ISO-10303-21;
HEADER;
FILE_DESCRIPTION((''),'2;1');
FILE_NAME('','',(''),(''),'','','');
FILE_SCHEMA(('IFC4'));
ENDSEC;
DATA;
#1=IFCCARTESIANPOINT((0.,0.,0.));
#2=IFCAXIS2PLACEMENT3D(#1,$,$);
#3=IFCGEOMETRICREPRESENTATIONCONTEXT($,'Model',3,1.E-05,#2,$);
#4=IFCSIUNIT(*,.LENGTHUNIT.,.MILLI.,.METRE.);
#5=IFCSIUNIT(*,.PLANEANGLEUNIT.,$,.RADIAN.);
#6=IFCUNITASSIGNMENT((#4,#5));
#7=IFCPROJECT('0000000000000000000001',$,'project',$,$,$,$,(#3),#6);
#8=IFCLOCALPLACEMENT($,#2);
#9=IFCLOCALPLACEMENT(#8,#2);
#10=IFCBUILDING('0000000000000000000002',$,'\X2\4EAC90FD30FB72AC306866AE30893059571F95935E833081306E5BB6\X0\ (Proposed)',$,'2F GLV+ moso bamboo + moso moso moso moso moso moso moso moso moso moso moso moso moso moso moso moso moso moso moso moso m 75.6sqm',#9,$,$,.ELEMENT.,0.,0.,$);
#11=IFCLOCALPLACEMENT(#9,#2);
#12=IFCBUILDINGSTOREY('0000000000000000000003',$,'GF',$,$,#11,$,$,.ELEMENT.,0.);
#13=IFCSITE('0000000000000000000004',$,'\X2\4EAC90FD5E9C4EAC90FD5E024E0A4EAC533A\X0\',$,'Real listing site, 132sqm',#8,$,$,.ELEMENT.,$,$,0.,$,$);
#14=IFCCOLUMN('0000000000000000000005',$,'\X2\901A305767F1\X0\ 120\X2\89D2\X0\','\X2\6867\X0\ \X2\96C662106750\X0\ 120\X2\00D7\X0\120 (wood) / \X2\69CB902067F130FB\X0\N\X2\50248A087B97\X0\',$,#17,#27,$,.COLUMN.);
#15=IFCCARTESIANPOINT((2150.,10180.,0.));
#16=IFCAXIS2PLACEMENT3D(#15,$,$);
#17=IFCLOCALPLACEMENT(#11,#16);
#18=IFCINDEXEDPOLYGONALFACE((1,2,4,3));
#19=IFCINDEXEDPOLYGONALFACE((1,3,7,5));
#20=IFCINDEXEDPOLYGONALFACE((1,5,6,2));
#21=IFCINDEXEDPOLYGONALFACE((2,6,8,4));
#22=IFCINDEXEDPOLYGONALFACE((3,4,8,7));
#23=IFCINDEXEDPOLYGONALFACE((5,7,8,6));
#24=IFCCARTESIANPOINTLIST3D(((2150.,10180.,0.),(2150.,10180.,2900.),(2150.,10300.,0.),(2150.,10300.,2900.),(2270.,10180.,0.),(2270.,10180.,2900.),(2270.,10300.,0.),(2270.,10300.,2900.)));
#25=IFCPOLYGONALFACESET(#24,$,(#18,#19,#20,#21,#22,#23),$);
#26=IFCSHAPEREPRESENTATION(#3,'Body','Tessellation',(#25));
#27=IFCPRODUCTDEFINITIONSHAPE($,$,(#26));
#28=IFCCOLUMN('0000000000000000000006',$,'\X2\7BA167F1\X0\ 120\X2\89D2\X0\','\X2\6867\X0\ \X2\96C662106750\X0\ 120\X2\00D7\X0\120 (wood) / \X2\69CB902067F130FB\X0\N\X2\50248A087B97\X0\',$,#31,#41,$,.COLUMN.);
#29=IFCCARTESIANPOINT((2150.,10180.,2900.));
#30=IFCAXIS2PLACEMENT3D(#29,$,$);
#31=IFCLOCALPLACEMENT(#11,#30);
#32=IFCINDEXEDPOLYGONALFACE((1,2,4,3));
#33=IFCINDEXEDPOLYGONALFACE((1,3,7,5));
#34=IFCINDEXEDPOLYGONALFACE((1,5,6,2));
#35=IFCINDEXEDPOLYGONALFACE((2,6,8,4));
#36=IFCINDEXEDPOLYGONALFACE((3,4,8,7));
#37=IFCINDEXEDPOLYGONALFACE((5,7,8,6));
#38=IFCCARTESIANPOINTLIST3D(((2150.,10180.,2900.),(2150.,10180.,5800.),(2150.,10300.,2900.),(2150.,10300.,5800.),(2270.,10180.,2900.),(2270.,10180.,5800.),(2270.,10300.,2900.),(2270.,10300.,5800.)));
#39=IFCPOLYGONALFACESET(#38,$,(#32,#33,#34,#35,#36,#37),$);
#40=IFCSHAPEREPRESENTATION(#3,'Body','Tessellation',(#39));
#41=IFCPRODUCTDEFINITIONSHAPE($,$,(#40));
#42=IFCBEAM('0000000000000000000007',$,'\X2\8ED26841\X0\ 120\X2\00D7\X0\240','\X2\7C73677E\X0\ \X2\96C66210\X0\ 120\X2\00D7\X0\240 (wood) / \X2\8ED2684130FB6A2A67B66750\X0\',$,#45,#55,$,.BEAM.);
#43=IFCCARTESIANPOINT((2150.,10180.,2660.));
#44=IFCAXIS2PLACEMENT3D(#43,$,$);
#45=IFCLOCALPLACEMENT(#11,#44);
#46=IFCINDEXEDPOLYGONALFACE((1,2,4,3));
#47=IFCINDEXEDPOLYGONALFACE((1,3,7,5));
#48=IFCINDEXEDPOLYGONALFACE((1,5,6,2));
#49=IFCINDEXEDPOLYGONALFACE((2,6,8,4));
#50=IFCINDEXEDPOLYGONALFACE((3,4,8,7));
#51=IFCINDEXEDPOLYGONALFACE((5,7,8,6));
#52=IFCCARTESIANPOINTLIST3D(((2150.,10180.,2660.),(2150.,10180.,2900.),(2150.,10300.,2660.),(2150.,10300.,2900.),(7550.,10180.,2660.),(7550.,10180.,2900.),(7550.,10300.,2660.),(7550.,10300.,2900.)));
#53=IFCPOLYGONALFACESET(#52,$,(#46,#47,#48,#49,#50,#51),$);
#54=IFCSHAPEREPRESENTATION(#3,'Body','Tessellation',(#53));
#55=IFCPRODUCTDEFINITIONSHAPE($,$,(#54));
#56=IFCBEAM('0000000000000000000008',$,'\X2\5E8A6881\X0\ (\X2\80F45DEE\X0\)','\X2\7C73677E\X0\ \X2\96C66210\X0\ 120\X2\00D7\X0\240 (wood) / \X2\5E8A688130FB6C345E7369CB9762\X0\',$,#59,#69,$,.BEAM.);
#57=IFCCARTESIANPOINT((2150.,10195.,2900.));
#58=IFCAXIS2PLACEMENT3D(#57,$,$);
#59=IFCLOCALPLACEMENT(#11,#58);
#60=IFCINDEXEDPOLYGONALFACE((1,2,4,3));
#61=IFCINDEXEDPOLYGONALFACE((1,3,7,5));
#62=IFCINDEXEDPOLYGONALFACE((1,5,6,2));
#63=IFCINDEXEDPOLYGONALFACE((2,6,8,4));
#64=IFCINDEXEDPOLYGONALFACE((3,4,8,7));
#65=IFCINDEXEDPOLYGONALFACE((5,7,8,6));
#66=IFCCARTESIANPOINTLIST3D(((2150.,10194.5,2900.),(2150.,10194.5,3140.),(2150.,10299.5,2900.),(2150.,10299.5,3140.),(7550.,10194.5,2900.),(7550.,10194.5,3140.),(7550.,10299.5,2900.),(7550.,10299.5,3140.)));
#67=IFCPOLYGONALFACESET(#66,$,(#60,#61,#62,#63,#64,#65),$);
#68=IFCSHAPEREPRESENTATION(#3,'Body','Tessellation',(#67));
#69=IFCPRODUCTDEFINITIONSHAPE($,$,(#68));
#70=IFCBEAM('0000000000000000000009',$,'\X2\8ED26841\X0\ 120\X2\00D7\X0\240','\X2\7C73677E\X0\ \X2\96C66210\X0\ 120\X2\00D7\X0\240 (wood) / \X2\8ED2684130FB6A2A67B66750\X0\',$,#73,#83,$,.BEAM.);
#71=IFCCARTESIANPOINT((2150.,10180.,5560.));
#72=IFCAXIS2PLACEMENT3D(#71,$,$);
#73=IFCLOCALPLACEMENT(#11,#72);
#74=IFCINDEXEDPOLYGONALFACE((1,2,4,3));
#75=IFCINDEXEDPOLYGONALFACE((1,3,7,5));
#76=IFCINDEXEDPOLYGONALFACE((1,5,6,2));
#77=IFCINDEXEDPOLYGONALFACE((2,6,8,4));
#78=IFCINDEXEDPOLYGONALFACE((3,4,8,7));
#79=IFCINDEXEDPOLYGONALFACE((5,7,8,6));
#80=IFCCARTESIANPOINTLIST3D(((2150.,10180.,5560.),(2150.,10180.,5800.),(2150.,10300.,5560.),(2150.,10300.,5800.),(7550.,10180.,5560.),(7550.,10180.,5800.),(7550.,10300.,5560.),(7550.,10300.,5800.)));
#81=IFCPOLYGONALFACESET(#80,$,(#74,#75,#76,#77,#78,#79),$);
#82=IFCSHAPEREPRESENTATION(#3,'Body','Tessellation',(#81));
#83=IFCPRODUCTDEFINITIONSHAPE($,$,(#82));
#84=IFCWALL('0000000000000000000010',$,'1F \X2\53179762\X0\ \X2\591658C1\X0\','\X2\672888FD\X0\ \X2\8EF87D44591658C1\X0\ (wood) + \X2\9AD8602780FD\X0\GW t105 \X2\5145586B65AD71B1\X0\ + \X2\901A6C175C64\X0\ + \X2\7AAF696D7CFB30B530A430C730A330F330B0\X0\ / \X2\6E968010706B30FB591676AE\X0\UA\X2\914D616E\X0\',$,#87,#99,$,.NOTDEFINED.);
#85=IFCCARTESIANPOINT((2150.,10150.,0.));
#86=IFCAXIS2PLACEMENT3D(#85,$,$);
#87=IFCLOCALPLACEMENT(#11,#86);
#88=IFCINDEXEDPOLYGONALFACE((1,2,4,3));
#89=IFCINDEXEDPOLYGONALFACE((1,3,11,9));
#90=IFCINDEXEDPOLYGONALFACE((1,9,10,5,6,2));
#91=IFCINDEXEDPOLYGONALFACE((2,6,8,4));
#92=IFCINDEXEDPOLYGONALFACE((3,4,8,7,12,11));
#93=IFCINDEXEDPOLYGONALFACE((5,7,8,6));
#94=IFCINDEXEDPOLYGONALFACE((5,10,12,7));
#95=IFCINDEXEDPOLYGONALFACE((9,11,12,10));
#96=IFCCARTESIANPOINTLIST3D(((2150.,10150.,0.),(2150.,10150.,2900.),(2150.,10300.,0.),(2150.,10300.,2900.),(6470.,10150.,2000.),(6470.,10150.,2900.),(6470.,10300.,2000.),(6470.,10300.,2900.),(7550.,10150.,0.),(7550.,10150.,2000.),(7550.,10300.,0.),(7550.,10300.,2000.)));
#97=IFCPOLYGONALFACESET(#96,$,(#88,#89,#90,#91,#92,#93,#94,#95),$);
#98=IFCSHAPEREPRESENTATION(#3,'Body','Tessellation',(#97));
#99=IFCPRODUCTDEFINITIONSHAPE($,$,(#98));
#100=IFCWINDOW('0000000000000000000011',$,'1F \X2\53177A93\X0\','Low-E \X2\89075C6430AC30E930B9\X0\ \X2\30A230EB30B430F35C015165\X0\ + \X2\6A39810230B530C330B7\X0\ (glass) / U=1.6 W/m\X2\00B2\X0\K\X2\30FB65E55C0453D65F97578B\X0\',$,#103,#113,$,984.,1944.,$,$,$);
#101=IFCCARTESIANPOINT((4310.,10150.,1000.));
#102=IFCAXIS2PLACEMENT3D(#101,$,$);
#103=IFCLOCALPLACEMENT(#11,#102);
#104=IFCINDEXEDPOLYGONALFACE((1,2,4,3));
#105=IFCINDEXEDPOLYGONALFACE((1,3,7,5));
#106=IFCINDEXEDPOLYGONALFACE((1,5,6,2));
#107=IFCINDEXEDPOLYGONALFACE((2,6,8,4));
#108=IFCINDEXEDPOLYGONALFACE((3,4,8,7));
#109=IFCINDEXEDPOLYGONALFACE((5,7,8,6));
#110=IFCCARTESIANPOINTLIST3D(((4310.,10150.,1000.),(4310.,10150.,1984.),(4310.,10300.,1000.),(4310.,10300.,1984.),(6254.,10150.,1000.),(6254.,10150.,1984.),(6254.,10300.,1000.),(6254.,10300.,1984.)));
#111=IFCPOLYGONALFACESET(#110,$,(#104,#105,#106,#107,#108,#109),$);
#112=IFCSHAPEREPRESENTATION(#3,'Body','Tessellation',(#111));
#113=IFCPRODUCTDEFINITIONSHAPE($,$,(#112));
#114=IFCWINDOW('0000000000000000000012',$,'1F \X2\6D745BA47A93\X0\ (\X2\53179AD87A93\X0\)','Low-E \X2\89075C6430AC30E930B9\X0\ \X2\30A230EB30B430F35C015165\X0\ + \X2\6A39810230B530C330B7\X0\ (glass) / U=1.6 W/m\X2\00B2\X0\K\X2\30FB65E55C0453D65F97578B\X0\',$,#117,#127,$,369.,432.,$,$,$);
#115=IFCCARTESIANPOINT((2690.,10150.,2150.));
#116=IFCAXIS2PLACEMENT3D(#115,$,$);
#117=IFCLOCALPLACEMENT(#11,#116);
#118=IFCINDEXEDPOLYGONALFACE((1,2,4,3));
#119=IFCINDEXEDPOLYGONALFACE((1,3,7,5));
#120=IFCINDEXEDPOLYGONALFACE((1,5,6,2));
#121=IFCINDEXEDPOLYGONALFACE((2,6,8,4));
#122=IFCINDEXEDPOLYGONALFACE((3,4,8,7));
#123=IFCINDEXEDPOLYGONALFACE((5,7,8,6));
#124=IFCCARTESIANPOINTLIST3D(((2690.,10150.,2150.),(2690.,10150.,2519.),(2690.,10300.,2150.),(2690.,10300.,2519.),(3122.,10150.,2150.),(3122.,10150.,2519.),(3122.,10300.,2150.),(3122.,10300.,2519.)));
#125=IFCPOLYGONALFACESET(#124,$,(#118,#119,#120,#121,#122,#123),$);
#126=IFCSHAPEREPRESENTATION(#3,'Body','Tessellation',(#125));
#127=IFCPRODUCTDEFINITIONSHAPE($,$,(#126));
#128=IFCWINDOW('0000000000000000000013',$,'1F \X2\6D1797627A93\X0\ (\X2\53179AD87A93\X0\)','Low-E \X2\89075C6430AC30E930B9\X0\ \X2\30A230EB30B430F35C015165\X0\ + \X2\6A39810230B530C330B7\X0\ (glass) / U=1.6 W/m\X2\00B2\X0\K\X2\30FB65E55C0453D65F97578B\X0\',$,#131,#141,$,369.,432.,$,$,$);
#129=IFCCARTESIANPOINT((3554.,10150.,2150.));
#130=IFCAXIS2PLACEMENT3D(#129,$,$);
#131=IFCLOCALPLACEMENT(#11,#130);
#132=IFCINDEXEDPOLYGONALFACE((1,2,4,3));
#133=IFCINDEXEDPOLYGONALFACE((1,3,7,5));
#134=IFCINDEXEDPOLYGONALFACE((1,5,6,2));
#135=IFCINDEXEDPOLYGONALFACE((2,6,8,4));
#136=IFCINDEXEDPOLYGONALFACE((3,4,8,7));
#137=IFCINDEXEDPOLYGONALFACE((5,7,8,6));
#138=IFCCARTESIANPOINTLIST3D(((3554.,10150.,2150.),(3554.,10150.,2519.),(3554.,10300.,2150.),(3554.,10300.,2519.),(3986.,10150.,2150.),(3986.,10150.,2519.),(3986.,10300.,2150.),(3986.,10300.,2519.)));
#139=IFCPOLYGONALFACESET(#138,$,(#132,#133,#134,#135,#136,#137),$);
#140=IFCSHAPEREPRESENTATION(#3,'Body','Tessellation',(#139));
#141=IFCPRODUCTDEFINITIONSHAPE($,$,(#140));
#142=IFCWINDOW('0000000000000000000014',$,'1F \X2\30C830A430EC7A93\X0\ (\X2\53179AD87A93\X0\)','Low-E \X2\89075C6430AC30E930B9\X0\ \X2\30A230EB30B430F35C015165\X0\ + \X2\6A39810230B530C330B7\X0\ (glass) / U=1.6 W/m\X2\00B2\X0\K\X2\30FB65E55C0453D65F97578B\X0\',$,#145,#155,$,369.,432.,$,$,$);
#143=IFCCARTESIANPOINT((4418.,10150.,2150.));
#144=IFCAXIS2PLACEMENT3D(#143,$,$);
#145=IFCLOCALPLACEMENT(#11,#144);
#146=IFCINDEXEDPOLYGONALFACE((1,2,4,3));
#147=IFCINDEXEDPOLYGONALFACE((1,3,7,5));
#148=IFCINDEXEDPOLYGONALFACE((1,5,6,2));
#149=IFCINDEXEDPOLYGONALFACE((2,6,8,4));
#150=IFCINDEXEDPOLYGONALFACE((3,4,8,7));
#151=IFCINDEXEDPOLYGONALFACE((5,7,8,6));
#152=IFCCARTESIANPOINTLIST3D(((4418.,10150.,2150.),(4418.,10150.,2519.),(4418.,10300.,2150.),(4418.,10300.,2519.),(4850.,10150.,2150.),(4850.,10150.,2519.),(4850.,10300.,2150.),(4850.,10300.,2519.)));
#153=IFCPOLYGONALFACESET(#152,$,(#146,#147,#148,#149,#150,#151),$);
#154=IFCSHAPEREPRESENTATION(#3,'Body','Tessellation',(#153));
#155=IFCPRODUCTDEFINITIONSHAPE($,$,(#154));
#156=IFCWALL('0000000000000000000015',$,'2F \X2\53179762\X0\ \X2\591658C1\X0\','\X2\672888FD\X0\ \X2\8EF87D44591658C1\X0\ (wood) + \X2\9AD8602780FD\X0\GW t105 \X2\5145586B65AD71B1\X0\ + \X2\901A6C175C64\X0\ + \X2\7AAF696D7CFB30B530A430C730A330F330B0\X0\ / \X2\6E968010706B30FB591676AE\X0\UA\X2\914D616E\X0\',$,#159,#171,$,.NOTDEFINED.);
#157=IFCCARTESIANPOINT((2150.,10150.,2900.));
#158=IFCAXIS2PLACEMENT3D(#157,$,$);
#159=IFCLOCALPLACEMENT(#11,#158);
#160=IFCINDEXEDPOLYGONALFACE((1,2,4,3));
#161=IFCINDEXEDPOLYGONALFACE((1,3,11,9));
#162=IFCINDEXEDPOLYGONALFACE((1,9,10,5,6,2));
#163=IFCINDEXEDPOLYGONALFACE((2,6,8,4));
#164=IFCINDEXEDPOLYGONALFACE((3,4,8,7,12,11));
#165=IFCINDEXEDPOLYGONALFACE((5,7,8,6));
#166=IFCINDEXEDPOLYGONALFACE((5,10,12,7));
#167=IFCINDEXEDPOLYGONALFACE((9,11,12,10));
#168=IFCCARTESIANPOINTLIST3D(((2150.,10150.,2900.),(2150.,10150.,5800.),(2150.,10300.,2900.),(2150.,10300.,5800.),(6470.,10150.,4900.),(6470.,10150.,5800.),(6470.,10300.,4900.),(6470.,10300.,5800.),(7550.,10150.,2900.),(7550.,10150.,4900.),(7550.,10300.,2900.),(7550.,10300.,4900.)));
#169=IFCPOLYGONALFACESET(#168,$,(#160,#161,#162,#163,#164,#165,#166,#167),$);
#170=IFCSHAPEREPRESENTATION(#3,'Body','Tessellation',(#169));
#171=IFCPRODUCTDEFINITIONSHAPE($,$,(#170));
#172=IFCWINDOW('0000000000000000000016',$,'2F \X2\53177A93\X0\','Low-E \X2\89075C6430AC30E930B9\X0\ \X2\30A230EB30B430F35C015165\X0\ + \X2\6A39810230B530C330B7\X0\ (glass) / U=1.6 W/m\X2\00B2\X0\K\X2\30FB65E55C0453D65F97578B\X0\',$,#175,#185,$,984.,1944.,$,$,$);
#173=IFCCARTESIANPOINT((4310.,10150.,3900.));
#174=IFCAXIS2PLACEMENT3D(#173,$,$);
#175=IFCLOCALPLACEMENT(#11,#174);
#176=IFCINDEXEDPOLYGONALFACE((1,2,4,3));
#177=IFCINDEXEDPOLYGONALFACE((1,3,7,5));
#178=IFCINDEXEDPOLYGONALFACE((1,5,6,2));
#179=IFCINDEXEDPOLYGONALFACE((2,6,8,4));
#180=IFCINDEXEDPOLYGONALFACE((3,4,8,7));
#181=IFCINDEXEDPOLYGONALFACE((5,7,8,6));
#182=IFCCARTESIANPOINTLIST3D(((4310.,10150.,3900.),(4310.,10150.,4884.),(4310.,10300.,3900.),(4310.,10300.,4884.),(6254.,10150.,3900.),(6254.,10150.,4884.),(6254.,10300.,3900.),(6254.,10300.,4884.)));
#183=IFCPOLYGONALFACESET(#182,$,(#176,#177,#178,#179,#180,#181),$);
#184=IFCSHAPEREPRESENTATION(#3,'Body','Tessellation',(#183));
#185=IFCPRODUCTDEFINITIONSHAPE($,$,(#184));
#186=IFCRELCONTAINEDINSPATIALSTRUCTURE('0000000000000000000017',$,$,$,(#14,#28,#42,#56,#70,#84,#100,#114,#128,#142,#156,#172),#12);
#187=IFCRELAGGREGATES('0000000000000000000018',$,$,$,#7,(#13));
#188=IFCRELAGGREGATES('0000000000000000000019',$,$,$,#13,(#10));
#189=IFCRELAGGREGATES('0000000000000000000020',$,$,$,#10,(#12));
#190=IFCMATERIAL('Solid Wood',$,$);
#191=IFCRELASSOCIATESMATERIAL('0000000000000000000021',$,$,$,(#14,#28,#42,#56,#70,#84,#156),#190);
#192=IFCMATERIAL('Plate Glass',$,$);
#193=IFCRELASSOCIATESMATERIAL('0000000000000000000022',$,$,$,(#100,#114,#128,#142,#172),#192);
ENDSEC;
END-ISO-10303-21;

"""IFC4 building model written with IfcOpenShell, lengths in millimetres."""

from ifc_helpers import new_model, si_unit, frame, frame_2d, origin, place, context, project, spatial, rectangle, extrude, material, element, fill, save


model = new_model("IFC4")

# Units and contexts
model_context = context("Model", 3, precision=1e-05, world=origin())
ifc_project = project(units=[si_unit("LENGTHUNIT", "METRE", prefix="MILLI"), si_unit("PLANEANGLEUNIT", "RADIAN")], contexts=[model_context])

# Site, building, storey
site_placement = place(None, origin())
site = spatial("IfcSite", under=ifc_project, at=site_placement, Name="京都府京都市上京区", ObjectType="Real listing site, 132sqm", CompositionType="ELEMENT", RefElevation=0.0)
building_placement = place(site_placement, origin())
building = spatial("IfcBuilding", under=site, at=building_placement, Name="京都・犬と暮らす土間広めの家 (Proposed)", ObjectType="2F GLV+ moso bamboo + moso moso moso moso moso moso moso moso moso moso moso moso moso moso moso moso moso moso moso moso m 75.6sqm", CompositionType="ELEMENT", ElevationOfRefHeight=0.0, ElevationOfTerrain=0.0)
storey_placement = place(building_placement, origin())
storey = spatial("IfcBuildingStorey", under=building, at=storey_placement, Name="GF", CompositionType="ELEMENT", Elevation=0.0)

# Columns
ifc_material_1 = material(Name="Solid Wood")
column_1_placement = place(storey_placement, frame((2150.0, 10180.0, 0.0)))
element("IfcColumn", 1, at=column_1_placement, inside=storey, material=ifc_material_1, Name="通し柱 120角", Description="桧 集成材 120×120 (wood) / 構造柱・N値計算", PredefinedType="COLUMN", context=model_context, shape_type="SweptSolid", body=[
    extrude(rectangle(XDim=120.0, YDim=120.0, at=frame_2d((60.0, 60.0))), frame((2150.0, 10180.0, 0.0)), (0.0, 0.0, 1.0), 2900.0),
])
column_2_placement = place(storey_placement, frame((2150.0, 10180.0, 2900.0)))
element("IfcColumn", 2, at=column_2_placement, inside=storey, material=ifc_material_1, Name="管柱 120角", Description="桧 集成材 120×120 (wood) / 構造柱・N値計算", PredefinedType="COLUMN", context=model_context, shape_type="SweptSolid", body=[
    extrude(rectangle(XDim=120.0, YDim=120.0, at=frame_2d((60.0, 60.0))), frame((2150.0, 10180.0, 2900.0)), (0.0, 0.0, 1.0), 2900.0),
])

# Beams
beam_1_placement = place(storey_placement, frame((2150.0, 10180.0, 2660.0)))
element("IfcBeam", 3, at=beam_1_placement, inside=storey, material=ifc_material_1, Name="軒桁 120×240", Description="米松 集成 120×240 (wood) / 軒桁・横架材", PredefinedType="BEAM", context=model_context, shape_type="SweptSolid", body=[
    extrude(rectangle(XDim=5400.0, YDim=120.0, at=frame_2d((2700.0, 60.0))), frame((2150.0, 10180.0, 2660.0)), (0.0, 0.0, 1.0), 240.0),
])
beam_2_placement = place(storey_placement, frame((2150.0, 10195.0, 2900.0)))
element("IfcBeam", 4, at=beam_2_placement, inside=storey, material=ifc_material_1, Name="床梁 (胴差)", Description="米松 集成 120×240 (wood) / 床梁・水平構面", PredefinedType="BEAM", context=model_context, shape_type="SweptSolid", body=[
    extrude(rectangle(XDim=5400.0, YDim=105.0, at=frame_2d((2700.0, 52.0))), frame((2150.0, 10195.0, 2900.0)), (0.0, 0.0, 1.0), 240.0),
])
beam_3_placement = place(storey_placement, frame((2150.0, 10180.0, 5560.0)))
element("IfcBeam", 5, at=beam_3_placement, inside=storey, material=ifc_material_1, Name="軒桁 120×240", Description="米松 集成 120×240 (wood) / 軒桁・横架材", PredefinedType="BEAM", context=model_context, shape_type="SweptSolid", body=[
    extrude(rectangle(XDim=5400.0, YDim=120.0, at=frame_2d((2700.0, 60.0))), frame((2150.0, 10180.0, 5560.0)), (0.0, 0.0, 1.0), 240.0),
])

# Wall, openings, windows
wall_1_placement = place(storey_placement, frame((2150.0, 10150.0, 0.0)))
wall_1 = element("IfcWall", 6, at=wall_1_placement, inside=storey, material=ifc_material_1, Name="1F 北面 外壁", Description="木製 軸組外壁 (wood) + 高性能GW t105 充填断熱 + 通気層 + 窯業系サイディング / 準耐火・外皮UA配慮", PredefinedType="NOTDEFINED", context=model_context, shape_type="SweptSolid", body=[
    extrude(rectangle(XDim=5400.0, YDim=150.0, at=frame_2d((2700.0, 75.0))), frame((2150.0, 10150.0, 0.0)), (0.0, 0.0, 1.0), 2900.0),
])
opening_1_placement = place(storey_placement, frame((4310.0, 10150.0, 1000.0)))
opening_1 = element("IfcOpeningElement", 7, at=opening_1_placement, cuts=wall_1, PredefinedType="NOTDEFINED", context=model_context, shape_type="SweptSolid", body=[
    extrude(rectangle(XDim=1944.0, YDim=150.0, at=frame_2d((972.0, 75.0))), frame((4310.0, 10150.0, 1000.0)), (0.0, 0.0, 1.0), 984.0),
])
opening_2_placement = place(storey_placement, frame((2690.0, 10150.0, 2150.0)))
opening_2 = element("IfcOpeningElement", 8, at=opening_2_placement, cuts=wall_1, PredefinedType="NOTDEFINED", context=model_context, shape_type="SweptSolid", body=[
    extrude(rectangle(XDim=432.0, YDim=150.0, at=frame_2d((216.0, 75.0))), frame((2690.0, 10150.0, 2150.0)), (0.0, 0.0, 1.0), 369.0),
])
opening_3_placement = place(storey_placement, frame((3554.0, 10150.0, 2150.0)))
opening_3 = element("IfcOpeningElement", 9, at=opening_3_placement, cuts=wall_1, PredefinedType="NOTDEFINED", context=model_context, shape_type="SweptSolid", body=[
    extrude(rectangle(XDim=432.0, YDim=150.0, at=frame_2d((216.0, 75.0))), frame((3554.0, 10150.0, 2150.0)), (0.0, 0.0, 1.0), 369.0),
])
opening_4_placement = place(storey_placement, frame((4418.0, 10150.0, 2150.0)))
opening_4 = element("IfcOpeningElement", 10, at=opening_4_placement, cuts=wall_1, PredefinedType="NOTDEFINED", context=model_context, shape_type="SweptSolid", body=[
    extrude(rectangle(XDim=432.0, YDim=150.0, at=frame_2d((216.0, 75.0))), frame((4418.0, 10150.0, 2150.0)), (0.0, 0.0, 1.0), 369.0),
])
ifc_material_2 = material(Name="Plate Glass")
window_1_placement = place(storey_placement, frame((4310.0, 10150.0, 1000.0)))
window_1 = element("IfcWindow", 11, at=window_1_placement, inside=storey, material=ifc_material_2, Name="1F 北窓", Description="Low-E 複層ガラス アルゴン封入 + 樹脂サッシ (glass) / U=1.6 W/m²K・日射取得型", OverallHeight=984.0, OverallWidth=1944.0, context=model_context, shape_type="SweptSolid", body=[
    extrude(rectangle(XDim=1944.0, YDim=150.0, at=frame_2d((972.0, 75.0))), frame((4310.0, 10150.0, 1000.0)), (0.0, 0.0, 1.0), 984.0),
])
fill(opening_1, window_1)
window_2_placement = place(storey_placement, frame((2690.0, 10150.0, 2150.0)))
window_2 = element("IfcWindow", 12, at=window_2_placement, inside=storey, material=ifc_material_2, Name="1F 浴室窓 (北高窓)", Description="Low-E 複層ガラス アルゴン封入 + 樹脂サッシ (glass) / U=1.6 W/m²K・日射取得型", OverallHeight=369.0, OverallWidth=432.0, context=model_context, shape_type="SweptSolid", body=[
    extrude(rectangle(XDim=432.0, YDim=150.0, at=frame_2d((216.0, 75.0))), frame((2690.0, 10150.0, 2150.0)), (0.0, 0.0, 1.0), 369.0),
])
fill(opening_2, window_2)
window_3_placement = place(storey_placement, frame((3554.0, 10150.0, 2150.0)))
window_3 = element("IfcWindow", 13, at=window_3_placement, inside=storey, material=ifc_material_2, Name="1F 洗面窓 (北高窓)", Description="Low-E 複層ガラス アルゴン封入 + 樹脂サッシ (glass) / U=1.6 W/m²K・日射取得型", OverallHeight=369.0, OverallWidth=432.0, context=model_context, shape_type="SweptSolid", body=[
    extrude(rectangle(XDim=432.0, YDim=150.0, at=frame_2d((216.0, 75.0))), frame((3554.0, 10150.0, 2150.0)), (0.0, 0.0, 1.0), 369.0),
])
fill(opening_3, window_3)
window_4_placement = place(storey_placement, frame((4418.0, 10150.0, 2150.0)))
window_4 = element("IfcWindow", 14, at=window_4_placement, inside=storey, material=ifc_material_2, Name="1F トイレ窓 (北高窓)", Description="Low-E 複層ガラス アルゴン封入 + 樹脂サッシ (glass) / U=1.6 W/m²K・日射取得型", OverallHeight=369.0, OverallWidth=432.0, context=model_context, shape_type="SweptSolid", body=[
    extrude(rectangle(XDim=432.0, YDim=150.0, at=frame_2d((216.0, 75.0))), frame((4418.0, 10150.0, 2150.0)), (0.0, 0.0, 1.0), 369.0),
])
fill(opening_4, window_4)

# Wall, opening, window
wall_2_placement = place(storey_placement, frame((2150.0, 10150.0, 2900.0)))
wall_2 = element("IfcWall", 15, at=wall_2_placement, inside=storey, material=ifc_material_1, Name="2F 北面 外壁", Description="木製 軸組外壁 (wood) + 高性能GW t105 充填断熱 + 通気層 + 窯業系サイディング / 準耐火・外皮UA配慮", PredefinedType="NOTDEFINED", context=model_context, shape_type="SweptSolid", body=[
    extrude(rectangle(XDim=5400.0, YDim=150.0, at=frame_2d((2700.0, 75.0))), frame((2150.0, 10150.0, 2900.0)), (0.0, 0.0, 1.0), 2900.0),
])
opening_5_placement = place(storey_placement, frame((4310.0, 10150.0, 3900.0)))
opening_5 = element("IfcOpeningElement", 16, at=opening_5_placement, cuts=wall_2, PredefinedType="NOTDEFINED", context=model_context, shape_type="SweptSolid", body=[
    extrude(rectangle(XDim=1944.0, YDim=150.0, at=frame_2d((972.0, 75.0))), frame((4310.0, 10150.0, 3900.0)), (0.0, 0.0, 1.0), 984.0),
])
window_5_placement = place(storey_placement, frame((4310.0, 10150.0, 3900.0)))
window_5 = element("IfcWindow", 17, at=window_5_placement, inside=storey, material=ifc_material_2, Name="2F 北窓", Description="Low-E 複層ガラス アルゴン封入 + 樹脂サッシ (glass) / U=1.6 W/m²K・日射取得型", OverallHeight=984.0, OverallWidth=1944.0, context=model_context, shape_type="SweptSolid", body=[
    extrude(rectangle(XDim=1944.0, YDim=150.0, at=frame_2d((972.0, 75.0))), frame((4310.0, 10150.0, 3900.0)), (0.0, 0.0, 1.0), 984.0),
])
fill(opening_5, window_5)

save(model, "model.ifc")
